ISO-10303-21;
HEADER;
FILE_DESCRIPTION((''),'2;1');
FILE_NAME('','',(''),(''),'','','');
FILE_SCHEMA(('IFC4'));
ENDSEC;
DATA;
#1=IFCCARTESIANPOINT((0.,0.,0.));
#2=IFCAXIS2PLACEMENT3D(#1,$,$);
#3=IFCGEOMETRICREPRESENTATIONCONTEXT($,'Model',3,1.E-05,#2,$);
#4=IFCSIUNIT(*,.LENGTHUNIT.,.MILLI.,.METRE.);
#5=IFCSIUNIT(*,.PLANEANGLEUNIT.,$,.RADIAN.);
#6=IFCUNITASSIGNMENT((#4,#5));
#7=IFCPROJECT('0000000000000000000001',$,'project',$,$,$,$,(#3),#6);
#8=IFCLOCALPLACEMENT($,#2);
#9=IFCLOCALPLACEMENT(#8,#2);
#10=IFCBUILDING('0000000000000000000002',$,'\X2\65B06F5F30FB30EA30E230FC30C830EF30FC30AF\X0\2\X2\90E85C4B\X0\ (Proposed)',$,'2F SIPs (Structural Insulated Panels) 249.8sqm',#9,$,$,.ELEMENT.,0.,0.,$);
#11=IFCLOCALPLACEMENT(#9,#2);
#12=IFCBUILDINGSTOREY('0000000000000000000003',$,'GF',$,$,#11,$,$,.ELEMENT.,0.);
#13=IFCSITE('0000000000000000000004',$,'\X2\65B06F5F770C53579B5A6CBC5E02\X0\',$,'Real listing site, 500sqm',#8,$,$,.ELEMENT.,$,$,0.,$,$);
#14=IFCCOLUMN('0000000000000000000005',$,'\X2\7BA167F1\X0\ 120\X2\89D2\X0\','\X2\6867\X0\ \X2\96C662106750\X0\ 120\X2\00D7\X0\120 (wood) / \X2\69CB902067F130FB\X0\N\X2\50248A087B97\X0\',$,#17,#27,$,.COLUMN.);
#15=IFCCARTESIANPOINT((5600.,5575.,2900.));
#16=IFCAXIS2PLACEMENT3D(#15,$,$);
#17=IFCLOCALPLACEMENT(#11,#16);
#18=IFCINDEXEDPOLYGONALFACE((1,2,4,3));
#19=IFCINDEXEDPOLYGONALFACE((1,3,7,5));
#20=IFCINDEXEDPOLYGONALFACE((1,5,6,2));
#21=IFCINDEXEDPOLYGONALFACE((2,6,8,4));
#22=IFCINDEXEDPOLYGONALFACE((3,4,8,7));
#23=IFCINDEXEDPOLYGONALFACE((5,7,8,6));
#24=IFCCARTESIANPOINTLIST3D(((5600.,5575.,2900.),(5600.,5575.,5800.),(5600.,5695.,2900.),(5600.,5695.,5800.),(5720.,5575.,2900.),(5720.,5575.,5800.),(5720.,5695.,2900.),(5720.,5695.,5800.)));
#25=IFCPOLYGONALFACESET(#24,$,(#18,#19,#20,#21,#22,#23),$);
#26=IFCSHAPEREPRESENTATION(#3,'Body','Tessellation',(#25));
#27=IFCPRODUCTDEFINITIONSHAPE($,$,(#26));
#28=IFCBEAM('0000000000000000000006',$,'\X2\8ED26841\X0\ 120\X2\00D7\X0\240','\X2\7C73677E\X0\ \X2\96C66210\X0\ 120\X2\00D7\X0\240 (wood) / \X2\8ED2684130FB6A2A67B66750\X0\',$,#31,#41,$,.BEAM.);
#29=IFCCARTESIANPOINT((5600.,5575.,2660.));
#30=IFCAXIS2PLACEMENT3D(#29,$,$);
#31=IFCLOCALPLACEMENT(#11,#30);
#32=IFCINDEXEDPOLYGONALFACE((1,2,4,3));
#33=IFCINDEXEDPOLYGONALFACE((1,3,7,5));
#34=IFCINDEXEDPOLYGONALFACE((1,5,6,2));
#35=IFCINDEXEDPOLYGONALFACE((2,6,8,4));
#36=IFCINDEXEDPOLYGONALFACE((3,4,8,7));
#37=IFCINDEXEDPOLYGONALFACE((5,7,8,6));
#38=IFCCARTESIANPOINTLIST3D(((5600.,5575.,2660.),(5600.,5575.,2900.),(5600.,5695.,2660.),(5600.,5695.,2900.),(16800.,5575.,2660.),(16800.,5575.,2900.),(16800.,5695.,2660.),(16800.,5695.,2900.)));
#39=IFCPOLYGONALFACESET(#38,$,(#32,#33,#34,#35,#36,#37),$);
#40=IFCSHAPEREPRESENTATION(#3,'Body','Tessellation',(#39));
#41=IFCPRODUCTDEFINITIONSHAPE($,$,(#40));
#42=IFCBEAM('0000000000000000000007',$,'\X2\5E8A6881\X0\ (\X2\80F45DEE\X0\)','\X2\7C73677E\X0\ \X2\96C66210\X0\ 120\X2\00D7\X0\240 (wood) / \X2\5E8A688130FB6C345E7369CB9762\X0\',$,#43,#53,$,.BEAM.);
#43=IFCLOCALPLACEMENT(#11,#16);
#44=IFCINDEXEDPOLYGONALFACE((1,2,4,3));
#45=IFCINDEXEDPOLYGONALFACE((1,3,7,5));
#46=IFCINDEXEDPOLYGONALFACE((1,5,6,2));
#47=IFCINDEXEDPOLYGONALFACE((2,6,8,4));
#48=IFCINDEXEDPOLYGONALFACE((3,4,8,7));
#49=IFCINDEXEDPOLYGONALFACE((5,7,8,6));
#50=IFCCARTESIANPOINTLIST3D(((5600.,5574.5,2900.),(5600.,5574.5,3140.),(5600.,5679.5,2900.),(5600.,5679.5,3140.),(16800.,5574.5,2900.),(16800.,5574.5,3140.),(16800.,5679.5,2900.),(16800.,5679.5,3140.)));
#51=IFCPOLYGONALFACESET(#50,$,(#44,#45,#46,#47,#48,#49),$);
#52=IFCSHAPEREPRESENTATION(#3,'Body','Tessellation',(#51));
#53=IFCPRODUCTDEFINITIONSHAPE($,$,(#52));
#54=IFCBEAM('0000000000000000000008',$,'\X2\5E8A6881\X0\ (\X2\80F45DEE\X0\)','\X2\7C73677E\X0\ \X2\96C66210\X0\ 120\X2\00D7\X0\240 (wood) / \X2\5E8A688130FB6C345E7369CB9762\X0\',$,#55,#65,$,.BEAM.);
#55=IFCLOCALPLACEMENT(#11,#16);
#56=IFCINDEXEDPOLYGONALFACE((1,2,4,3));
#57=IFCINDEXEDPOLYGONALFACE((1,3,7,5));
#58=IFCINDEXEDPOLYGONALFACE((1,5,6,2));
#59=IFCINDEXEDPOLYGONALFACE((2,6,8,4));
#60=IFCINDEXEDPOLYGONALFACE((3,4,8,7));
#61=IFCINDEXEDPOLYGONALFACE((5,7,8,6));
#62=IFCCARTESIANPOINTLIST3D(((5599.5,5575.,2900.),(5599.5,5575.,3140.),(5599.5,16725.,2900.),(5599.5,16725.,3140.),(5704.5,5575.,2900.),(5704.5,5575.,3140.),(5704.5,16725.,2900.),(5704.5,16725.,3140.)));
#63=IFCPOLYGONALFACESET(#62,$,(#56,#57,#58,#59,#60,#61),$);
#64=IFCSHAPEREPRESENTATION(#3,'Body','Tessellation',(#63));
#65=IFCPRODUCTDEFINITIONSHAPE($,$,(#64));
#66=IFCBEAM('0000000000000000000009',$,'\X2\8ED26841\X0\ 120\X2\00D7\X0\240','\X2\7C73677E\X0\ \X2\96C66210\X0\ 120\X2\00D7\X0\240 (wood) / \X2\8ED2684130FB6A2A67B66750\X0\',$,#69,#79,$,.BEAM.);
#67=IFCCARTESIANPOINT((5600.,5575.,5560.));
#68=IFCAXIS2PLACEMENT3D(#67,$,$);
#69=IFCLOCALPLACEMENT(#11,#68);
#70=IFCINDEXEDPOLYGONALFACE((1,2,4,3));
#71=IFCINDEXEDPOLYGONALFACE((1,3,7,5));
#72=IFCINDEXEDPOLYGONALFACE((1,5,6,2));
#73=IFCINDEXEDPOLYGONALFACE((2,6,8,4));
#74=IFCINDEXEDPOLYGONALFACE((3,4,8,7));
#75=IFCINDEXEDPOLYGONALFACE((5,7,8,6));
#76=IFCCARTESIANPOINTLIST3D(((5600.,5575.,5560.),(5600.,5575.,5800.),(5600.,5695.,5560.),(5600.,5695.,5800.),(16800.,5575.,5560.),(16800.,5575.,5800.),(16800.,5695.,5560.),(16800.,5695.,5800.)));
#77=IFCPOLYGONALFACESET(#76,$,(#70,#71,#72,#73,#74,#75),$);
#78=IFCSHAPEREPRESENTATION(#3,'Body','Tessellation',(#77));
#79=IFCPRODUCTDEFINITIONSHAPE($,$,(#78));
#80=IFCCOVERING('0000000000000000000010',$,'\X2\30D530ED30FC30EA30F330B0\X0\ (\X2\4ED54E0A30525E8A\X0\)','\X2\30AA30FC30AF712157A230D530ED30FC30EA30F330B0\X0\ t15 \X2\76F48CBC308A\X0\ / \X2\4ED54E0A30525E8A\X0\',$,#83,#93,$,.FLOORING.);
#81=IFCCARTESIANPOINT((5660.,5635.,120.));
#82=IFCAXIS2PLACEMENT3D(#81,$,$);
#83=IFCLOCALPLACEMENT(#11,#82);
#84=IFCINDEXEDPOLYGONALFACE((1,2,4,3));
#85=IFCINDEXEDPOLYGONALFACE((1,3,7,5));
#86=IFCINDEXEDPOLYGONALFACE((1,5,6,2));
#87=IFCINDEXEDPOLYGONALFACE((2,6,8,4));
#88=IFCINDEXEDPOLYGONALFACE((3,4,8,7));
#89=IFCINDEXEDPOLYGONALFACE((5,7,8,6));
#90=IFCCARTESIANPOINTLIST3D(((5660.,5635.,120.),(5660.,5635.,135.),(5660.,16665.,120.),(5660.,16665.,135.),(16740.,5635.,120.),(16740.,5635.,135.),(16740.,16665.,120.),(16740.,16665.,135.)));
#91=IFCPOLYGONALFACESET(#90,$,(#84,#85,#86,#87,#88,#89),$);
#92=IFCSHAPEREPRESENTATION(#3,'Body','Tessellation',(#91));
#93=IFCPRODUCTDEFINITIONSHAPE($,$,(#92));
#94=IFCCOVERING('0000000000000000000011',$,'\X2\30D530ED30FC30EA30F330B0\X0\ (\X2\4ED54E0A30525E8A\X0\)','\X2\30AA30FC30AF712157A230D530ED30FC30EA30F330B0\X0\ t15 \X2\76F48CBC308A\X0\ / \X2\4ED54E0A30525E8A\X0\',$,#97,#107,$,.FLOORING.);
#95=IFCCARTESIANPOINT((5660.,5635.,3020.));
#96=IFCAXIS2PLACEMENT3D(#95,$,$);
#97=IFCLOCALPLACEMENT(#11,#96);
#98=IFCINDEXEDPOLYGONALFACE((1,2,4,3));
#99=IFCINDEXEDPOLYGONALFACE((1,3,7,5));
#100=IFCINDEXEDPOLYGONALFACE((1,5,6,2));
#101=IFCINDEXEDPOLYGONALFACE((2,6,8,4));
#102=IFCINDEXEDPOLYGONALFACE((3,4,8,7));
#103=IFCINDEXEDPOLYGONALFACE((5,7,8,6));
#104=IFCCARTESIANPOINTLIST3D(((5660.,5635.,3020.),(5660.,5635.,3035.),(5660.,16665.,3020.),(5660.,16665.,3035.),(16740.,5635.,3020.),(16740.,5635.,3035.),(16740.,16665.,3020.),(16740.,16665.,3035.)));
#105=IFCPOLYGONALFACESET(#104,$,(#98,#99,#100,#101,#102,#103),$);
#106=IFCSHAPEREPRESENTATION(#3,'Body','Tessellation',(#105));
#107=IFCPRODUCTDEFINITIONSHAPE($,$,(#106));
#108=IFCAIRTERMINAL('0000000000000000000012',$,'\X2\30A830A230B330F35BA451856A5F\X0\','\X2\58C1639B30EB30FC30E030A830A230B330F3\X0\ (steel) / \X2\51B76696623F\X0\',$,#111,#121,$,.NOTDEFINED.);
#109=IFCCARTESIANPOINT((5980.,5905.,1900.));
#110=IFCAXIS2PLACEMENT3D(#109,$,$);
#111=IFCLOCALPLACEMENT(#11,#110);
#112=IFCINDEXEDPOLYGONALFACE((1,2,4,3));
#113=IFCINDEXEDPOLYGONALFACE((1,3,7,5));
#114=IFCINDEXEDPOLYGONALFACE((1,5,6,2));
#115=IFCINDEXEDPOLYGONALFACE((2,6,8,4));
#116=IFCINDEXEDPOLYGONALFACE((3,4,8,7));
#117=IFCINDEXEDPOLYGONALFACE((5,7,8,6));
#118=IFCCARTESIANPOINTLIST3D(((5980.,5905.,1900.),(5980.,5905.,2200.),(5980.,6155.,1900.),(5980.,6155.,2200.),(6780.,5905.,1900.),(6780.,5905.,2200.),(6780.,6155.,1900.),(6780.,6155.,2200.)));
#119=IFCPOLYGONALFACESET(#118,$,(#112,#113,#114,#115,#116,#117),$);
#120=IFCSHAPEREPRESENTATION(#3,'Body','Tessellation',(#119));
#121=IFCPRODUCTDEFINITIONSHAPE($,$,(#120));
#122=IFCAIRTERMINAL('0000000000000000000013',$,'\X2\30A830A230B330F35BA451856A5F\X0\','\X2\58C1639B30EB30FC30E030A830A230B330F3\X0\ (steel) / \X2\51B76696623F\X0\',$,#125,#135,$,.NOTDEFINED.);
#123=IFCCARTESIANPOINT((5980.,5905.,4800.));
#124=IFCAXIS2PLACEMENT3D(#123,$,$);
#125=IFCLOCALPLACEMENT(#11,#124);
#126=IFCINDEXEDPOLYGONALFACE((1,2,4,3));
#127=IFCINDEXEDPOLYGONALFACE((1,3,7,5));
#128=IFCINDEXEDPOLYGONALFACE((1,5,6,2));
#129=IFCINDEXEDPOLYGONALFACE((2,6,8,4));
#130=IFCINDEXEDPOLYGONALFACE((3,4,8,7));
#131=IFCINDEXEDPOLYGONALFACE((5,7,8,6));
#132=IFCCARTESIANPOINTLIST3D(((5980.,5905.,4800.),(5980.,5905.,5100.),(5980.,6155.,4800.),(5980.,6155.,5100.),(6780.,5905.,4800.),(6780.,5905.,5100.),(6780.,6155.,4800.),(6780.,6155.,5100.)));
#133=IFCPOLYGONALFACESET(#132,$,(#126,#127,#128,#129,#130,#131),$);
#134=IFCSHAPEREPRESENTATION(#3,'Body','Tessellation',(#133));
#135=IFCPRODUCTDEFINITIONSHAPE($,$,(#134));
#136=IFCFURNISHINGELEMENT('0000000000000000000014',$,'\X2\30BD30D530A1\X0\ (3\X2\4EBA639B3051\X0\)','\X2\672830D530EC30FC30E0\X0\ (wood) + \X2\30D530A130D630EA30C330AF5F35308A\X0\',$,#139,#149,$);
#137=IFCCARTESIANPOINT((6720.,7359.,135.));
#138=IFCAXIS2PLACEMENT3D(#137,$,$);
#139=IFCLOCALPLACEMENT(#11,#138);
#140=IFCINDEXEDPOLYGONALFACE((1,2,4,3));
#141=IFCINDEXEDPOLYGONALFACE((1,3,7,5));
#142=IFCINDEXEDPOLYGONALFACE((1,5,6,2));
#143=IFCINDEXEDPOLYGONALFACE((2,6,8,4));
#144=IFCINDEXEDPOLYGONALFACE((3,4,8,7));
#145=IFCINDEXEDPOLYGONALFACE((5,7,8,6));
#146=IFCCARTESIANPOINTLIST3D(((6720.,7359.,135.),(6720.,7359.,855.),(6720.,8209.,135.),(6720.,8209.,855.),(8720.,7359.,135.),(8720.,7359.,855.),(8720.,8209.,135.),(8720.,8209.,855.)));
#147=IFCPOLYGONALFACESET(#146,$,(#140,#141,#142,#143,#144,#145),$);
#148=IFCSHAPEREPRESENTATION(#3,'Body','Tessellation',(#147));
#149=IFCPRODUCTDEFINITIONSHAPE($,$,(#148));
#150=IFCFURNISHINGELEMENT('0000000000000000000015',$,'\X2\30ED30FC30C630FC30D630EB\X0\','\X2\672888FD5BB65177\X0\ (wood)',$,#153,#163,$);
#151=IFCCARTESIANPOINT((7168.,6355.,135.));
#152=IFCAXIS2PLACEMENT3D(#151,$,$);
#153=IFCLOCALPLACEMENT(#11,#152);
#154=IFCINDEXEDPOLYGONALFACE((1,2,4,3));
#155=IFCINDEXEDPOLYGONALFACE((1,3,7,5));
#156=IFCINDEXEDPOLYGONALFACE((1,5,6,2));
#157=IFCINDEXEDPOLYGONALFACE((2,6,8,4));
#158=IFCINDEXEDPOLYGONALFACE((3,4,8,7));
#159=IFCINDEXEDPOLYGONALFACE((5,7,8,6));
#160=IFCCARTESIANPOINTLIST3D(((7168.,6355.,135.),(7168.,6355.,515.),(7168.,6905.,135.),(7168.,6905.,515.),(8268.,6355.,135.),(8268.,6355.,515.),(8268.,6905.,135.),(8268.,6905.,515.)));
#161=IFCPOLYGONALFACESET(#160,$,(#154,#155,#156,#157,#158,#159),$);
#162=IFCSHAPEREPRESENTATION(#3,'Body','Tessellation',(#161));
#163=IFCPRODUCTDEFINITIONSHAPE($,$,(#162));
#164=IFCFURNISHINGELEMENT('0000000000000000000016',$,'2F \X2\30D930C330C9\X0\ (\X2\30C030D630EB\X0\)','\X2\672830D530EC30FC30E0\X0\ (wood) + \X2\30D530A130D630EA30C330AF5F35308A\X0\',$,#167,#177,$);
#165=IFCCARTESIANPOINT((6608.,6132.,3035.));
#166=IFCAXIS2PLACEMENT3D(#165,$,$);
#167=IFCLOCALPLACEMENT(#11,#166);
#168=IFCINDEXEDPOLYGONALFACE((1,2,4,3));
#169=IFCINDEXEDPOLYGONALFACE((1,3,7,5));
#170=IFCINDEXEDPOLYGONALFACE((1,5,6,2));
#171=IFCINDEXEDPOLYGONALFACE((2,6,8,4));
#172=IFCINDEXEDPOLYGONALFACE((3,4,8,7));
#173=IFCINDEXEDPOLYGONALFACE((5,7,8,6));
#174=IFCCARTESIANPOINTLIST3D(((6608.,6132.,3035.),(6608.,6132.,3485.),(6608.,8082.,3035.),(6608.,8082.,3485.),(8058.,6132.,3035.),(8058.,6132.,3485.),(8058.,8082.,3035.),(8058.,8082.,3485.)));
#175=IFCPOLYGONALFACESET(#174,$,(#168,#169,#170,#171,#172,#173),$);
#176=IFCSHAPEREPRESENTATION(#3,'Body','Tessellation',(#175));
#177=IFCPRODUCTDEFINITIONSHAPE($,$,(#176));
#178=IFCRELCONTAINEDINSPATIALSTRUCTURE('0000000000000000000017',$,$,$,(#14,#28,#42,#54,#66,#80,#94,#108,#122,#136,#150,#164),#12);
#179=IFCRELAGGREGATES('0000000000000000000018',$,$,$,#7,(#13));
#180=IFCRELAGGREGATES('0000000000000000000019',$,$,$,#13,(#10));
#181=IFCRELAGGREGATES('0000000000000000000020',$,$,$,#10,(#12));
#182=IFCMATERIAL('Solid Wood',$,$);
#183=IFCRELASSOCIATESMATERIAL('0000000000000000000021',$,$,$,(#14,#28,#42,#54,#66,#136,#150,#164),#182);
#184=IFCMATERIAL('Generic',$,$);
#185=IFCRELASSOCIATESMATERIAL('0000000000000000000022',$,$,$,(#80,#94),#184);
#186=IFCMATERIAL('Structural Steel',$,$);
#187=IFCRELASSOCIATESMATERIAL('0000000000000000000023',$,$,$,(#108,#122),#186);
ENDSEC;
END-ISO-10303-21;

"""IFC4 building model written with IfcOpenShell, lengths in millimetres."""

from ifc_helpers import new_model, si_unit, frame, frame_2d, origin, place, context, project, spatial, rectangle, extrude, material, element, save


model = new_model("IFC4")

# Units and contexts
model_context = context("Model", 3, precision=1e-05, world=origin())
ifc_project = project(units=[si_unit("LENGTHUNIT", "METRE", prefix="MILLI"), si_unit("PLANEANGLEUNIT", "RADIAN")], contexts=[model_context])

# Site, building, storey
site_placement = place(None, origin())
site = spatial("IfcSite", under=ifc_project, at=site_placement, Name="新潟県南魚沼市", ObjectType="Real listing site, 500sqm", CompositionType="ELEMENT", RefElevation=0.0)
building_placement = place(site_placement, origin())
building = spatial("IfcBuilding", under=site, at=building_placement, Name="新潟・リモートワーク2部屋 (Proposed)", ObjectType="2F SIPs (Structural Insulated Panels) 249.8sqm", CompositionType="ELEMENT", ElevationOfRefHeight=0.0, ElevationOfTerrain=0.0)
storey_placement = place(building_placement, origin())
storey = spatial("IfcBuildingStorey", under=building, at=storey_placement, Name="GF", CompositionType="ELEMENT", Elevation=0.0)

# Column
ifc_material_1 = material(Name="Solid Wood")
column_1_placement = place(storey_placement, frame((5600.0, 5575.0, 2900.0)))
element("IfcColumn", 1, at=column_1_placement, inside=storey, material=ifc_material_1, Name="管柱 120角", Description="桧 集成材 120×120 (wood) / 構造柱・N値計算", PredefinedType="COLUMN", context=model_context, shape_type="SweptSolid", body=[
    extrude(rectangle(XDim=120.0, YDim=120.0, at=frame_2d((60.0, 60.0))), frame((5600.0, 5575.0, 2900.0)), (0.0, 0.0, 1.0), 2900.0),
])

# Beams
beam_1_placement = place(storey_placement, frame((5600.0, 5575.0, 2660.0)))
element("IfcBeam", 2, at=beam_1_placement, inside=storey, material=ifc_material_1, Name="軒桁 120×240", Description="米松 集成 120×240 (wood) / 軒桁・横架材", PredefinedType="BEAM", context=model_context, shape_type="SweptSolid", body=[
    extrude(rectangle(XDim=11200.0, YDim=120.0, at=frame_2d((5600.0, 60.0))), frame((5600.0, 5575.0, 2660.0)), (0.0, 0.0, 1.0), 240.0),
])
beam_2_placement = place(storey_placement, frame((5600.0, 5575.0, 2900.0)))
element("IfcBeam", 3, at=beam_2_placement, inside=storey, material=ifc_material_1, Name="床梁 (胴差)", Description="米松 集成 120×240 (wood) / 床梁・水平構面", PredefinedType="BEAM", context=model_context, shape_type="SweptSolid", body=[
    extrude(rectangle(XDim=11200.0, YDim=105.0, at=frame_2d((5600.0, 52.0))), frame((5600.0, 5575.0, 2900.0)), (0.0, 0.0, 1.0), 240.0),
])
beam_3_placement = place(storey_placement, frame((5600.0, 5575.0, 2900.0)))
element("IfcBeam", 4, at=beam_3_placement, inside=storey, material=ifc_material_1, Name="床梁 (胴差)", Description="米松 集成 120×240 (wood) / 床梁・水平構面", PredefinedType="BEAM", context=model_context, shape_type="SweptSolid", body=[
    extrude(rectangle(XDim=105.0, YDim=11150.0, at=frame_2d((52.0, 5575.0))), frame((5600.0, 5575.0, 2900.0)), (0.0, 0.0, 1.0), 240.0),
])
beam_4_placement = place(storey_placement, frame((5600.0, 5575.0, 5560.0)))
element("IfcBeam", 5, at=beam_4_placement, inside=storey, material=ifc_material_1, Name="軒桁 120×240", Description="米松 集成 120×240 (wood) / 軒桁・横架材", PredefinedType="BEAM", context=model_context, shape_type="SweptSolid", body=[
    extrude(rectangle(XDim=11200.0, YDim=120.0, at=frame_2d((5600.0, 60.0))), frame((5600.0, 5575.0, 5560.0)), (0.0, 0.0, 1.0), 240.0),
])

# Coverings
ifc_material_2 = material(Name="Generic")
covering_1_placement = place(storey_placement, frame((5660.0, 5635.0, 120.0)))
element("IfcCovering", 6, at=covering_1_placement, inside=storey, material=ifc_material_2, Name="フローリング (仕上げ床)", Description="オーク無垢フローリング t15 直貼り / 仕上げ床", PredefinedType="FLOORING", context=model_context, shape_type="SweptSolid", body=[
    extrude(rectangle(XDim=11080.0, YDim=11030.0, at=frame_2d((5540.0, 5515.0))), frame((5660.0, 5635.0, 120.0)), (0.0, 0.0, 1.0), 15.0),
])
covering_2_placement = place(storey_placement, frame((5660.0, 5635.0, 3020.0)))
element("IfcCovering", 7, at=covering_2_placement, inside=storey, material=ifc_material_2, Name="フローリング (仕上げ床)", Description="オーク無垢フローリング t15 直貼り / 仕上げ床", PredefinedType="FLOORING", context=model_context, shape_type="SweptSolid", body=[
    extrude(rectangle(XDim=11080.0, YDim=11030.0, at=frame_2d((5540.0, 5515.0))), frame((5660.0, 5635.0, 3020.0)), (0.0, 0.0, 1.0), 15.0),
])

# Air terminals
ifc_material_3 = material(Name="Structural Steel")
air_terminal_1_placement = place(storey_placement, frame((5980.0, 5905.0, 1900.0)))
element("IfcAirTerminal", 8, at=air_terminal_1_placement, inside=storey, material=ifc_material_3, Name="エアコン室内機", Description="壁掛ルームエアコン (steel) / 冷暖房", PredefinedType="NOTDEFINED", context=model_context, shape_type="SweptSolid", body=[
    extrude(rectangle(XDim=800.0, YDim=250.0, at=frame_2d((400.0, 125.0))), frame((5980.0, 5905.0, 1900.0)), (0.0, 0.0, 1.0), 300.0),
])
air_terminal_2_placement = place(storey_placement, frame((5980.0, 5905.0, 4800.0)))
element("IfcAirTerminal", 9, at=air_terminal_2_placement, inside=storey, material=ifc_material_3, Name="エアコン室内機", Description="壁掛ルームエアコン (steel) / 冷暖房", PredefinedType="NOTDEFINED", context=model_context, shape_type="SweptSolid", body=[
    extrude(rectangle(XDim=800.0, YDim=250.0, at=frame_2d((400.0, 125.0))), frame((5980.0, 5905.0, 4800.0)), (0.0, 0.0, 1.0), 300.0),
])

# Furnishing elements
furnishing_1_placement = place(storey_placement, frame((6720.0, 7359.0, 135.0)))
element("IfcFurnishingElement", 10, at=furnishing_1_placement, inside=storey, material=ifc_material_1, Name="ソファ (3人掛け)", Description="木フレーム (wood) + ファブリック張り", context=model_context, shape_type="SweptSolid", body=[
    extrude(rectangle(XDim=2000.0, YDim=850.0, at=frame_2d((1000.0, 425.0))), frame((6720.0, 7359.0, 135.0)), (0.0, 0.0, 1.0), 720.0),
])
furnishing_2_placement = place(storey_placement, frame((7168.0, 6355.0, 135.0)))
element("IfcFurnishingElement", 11, at=furnishing_2_placement, inside=storey, material=ifc_material_1, Name="ローテーブル", Description="木製家具 (wood)", context=model_context, shape_type="SweptSolid", body=[
    extrude(rectangle(XDim=1100.0, YDim=550.0, at=frame_2d((550.0, 275.0))), frame((7168.0, 6355.0, 135.0)), (0.0, 0.0, 1.0), 380.0),
])
furnishing_3_placement = place(storey_placement, frame((6608.0, 6132.0, 3035.0)))
element("IfcFurnishingElement", 12, at=furnishing_3_placement, inside=storey, material=ifc_material_1, Name="2F ベッド (ダブル)", Description="木フレーム (wood) + ファブリック張り", context=model_context, shape_type="SweptSolid", body=[
    extrude(rectangle(XDim=1450.0, YDim=1950.0, at=frame_2d((725.0, 975.0))), frame((6608.0, 6132.0, 3035.0)), (0.0, 0.0, 1.0), 450.0),
])

save(model, "model.ifc")
